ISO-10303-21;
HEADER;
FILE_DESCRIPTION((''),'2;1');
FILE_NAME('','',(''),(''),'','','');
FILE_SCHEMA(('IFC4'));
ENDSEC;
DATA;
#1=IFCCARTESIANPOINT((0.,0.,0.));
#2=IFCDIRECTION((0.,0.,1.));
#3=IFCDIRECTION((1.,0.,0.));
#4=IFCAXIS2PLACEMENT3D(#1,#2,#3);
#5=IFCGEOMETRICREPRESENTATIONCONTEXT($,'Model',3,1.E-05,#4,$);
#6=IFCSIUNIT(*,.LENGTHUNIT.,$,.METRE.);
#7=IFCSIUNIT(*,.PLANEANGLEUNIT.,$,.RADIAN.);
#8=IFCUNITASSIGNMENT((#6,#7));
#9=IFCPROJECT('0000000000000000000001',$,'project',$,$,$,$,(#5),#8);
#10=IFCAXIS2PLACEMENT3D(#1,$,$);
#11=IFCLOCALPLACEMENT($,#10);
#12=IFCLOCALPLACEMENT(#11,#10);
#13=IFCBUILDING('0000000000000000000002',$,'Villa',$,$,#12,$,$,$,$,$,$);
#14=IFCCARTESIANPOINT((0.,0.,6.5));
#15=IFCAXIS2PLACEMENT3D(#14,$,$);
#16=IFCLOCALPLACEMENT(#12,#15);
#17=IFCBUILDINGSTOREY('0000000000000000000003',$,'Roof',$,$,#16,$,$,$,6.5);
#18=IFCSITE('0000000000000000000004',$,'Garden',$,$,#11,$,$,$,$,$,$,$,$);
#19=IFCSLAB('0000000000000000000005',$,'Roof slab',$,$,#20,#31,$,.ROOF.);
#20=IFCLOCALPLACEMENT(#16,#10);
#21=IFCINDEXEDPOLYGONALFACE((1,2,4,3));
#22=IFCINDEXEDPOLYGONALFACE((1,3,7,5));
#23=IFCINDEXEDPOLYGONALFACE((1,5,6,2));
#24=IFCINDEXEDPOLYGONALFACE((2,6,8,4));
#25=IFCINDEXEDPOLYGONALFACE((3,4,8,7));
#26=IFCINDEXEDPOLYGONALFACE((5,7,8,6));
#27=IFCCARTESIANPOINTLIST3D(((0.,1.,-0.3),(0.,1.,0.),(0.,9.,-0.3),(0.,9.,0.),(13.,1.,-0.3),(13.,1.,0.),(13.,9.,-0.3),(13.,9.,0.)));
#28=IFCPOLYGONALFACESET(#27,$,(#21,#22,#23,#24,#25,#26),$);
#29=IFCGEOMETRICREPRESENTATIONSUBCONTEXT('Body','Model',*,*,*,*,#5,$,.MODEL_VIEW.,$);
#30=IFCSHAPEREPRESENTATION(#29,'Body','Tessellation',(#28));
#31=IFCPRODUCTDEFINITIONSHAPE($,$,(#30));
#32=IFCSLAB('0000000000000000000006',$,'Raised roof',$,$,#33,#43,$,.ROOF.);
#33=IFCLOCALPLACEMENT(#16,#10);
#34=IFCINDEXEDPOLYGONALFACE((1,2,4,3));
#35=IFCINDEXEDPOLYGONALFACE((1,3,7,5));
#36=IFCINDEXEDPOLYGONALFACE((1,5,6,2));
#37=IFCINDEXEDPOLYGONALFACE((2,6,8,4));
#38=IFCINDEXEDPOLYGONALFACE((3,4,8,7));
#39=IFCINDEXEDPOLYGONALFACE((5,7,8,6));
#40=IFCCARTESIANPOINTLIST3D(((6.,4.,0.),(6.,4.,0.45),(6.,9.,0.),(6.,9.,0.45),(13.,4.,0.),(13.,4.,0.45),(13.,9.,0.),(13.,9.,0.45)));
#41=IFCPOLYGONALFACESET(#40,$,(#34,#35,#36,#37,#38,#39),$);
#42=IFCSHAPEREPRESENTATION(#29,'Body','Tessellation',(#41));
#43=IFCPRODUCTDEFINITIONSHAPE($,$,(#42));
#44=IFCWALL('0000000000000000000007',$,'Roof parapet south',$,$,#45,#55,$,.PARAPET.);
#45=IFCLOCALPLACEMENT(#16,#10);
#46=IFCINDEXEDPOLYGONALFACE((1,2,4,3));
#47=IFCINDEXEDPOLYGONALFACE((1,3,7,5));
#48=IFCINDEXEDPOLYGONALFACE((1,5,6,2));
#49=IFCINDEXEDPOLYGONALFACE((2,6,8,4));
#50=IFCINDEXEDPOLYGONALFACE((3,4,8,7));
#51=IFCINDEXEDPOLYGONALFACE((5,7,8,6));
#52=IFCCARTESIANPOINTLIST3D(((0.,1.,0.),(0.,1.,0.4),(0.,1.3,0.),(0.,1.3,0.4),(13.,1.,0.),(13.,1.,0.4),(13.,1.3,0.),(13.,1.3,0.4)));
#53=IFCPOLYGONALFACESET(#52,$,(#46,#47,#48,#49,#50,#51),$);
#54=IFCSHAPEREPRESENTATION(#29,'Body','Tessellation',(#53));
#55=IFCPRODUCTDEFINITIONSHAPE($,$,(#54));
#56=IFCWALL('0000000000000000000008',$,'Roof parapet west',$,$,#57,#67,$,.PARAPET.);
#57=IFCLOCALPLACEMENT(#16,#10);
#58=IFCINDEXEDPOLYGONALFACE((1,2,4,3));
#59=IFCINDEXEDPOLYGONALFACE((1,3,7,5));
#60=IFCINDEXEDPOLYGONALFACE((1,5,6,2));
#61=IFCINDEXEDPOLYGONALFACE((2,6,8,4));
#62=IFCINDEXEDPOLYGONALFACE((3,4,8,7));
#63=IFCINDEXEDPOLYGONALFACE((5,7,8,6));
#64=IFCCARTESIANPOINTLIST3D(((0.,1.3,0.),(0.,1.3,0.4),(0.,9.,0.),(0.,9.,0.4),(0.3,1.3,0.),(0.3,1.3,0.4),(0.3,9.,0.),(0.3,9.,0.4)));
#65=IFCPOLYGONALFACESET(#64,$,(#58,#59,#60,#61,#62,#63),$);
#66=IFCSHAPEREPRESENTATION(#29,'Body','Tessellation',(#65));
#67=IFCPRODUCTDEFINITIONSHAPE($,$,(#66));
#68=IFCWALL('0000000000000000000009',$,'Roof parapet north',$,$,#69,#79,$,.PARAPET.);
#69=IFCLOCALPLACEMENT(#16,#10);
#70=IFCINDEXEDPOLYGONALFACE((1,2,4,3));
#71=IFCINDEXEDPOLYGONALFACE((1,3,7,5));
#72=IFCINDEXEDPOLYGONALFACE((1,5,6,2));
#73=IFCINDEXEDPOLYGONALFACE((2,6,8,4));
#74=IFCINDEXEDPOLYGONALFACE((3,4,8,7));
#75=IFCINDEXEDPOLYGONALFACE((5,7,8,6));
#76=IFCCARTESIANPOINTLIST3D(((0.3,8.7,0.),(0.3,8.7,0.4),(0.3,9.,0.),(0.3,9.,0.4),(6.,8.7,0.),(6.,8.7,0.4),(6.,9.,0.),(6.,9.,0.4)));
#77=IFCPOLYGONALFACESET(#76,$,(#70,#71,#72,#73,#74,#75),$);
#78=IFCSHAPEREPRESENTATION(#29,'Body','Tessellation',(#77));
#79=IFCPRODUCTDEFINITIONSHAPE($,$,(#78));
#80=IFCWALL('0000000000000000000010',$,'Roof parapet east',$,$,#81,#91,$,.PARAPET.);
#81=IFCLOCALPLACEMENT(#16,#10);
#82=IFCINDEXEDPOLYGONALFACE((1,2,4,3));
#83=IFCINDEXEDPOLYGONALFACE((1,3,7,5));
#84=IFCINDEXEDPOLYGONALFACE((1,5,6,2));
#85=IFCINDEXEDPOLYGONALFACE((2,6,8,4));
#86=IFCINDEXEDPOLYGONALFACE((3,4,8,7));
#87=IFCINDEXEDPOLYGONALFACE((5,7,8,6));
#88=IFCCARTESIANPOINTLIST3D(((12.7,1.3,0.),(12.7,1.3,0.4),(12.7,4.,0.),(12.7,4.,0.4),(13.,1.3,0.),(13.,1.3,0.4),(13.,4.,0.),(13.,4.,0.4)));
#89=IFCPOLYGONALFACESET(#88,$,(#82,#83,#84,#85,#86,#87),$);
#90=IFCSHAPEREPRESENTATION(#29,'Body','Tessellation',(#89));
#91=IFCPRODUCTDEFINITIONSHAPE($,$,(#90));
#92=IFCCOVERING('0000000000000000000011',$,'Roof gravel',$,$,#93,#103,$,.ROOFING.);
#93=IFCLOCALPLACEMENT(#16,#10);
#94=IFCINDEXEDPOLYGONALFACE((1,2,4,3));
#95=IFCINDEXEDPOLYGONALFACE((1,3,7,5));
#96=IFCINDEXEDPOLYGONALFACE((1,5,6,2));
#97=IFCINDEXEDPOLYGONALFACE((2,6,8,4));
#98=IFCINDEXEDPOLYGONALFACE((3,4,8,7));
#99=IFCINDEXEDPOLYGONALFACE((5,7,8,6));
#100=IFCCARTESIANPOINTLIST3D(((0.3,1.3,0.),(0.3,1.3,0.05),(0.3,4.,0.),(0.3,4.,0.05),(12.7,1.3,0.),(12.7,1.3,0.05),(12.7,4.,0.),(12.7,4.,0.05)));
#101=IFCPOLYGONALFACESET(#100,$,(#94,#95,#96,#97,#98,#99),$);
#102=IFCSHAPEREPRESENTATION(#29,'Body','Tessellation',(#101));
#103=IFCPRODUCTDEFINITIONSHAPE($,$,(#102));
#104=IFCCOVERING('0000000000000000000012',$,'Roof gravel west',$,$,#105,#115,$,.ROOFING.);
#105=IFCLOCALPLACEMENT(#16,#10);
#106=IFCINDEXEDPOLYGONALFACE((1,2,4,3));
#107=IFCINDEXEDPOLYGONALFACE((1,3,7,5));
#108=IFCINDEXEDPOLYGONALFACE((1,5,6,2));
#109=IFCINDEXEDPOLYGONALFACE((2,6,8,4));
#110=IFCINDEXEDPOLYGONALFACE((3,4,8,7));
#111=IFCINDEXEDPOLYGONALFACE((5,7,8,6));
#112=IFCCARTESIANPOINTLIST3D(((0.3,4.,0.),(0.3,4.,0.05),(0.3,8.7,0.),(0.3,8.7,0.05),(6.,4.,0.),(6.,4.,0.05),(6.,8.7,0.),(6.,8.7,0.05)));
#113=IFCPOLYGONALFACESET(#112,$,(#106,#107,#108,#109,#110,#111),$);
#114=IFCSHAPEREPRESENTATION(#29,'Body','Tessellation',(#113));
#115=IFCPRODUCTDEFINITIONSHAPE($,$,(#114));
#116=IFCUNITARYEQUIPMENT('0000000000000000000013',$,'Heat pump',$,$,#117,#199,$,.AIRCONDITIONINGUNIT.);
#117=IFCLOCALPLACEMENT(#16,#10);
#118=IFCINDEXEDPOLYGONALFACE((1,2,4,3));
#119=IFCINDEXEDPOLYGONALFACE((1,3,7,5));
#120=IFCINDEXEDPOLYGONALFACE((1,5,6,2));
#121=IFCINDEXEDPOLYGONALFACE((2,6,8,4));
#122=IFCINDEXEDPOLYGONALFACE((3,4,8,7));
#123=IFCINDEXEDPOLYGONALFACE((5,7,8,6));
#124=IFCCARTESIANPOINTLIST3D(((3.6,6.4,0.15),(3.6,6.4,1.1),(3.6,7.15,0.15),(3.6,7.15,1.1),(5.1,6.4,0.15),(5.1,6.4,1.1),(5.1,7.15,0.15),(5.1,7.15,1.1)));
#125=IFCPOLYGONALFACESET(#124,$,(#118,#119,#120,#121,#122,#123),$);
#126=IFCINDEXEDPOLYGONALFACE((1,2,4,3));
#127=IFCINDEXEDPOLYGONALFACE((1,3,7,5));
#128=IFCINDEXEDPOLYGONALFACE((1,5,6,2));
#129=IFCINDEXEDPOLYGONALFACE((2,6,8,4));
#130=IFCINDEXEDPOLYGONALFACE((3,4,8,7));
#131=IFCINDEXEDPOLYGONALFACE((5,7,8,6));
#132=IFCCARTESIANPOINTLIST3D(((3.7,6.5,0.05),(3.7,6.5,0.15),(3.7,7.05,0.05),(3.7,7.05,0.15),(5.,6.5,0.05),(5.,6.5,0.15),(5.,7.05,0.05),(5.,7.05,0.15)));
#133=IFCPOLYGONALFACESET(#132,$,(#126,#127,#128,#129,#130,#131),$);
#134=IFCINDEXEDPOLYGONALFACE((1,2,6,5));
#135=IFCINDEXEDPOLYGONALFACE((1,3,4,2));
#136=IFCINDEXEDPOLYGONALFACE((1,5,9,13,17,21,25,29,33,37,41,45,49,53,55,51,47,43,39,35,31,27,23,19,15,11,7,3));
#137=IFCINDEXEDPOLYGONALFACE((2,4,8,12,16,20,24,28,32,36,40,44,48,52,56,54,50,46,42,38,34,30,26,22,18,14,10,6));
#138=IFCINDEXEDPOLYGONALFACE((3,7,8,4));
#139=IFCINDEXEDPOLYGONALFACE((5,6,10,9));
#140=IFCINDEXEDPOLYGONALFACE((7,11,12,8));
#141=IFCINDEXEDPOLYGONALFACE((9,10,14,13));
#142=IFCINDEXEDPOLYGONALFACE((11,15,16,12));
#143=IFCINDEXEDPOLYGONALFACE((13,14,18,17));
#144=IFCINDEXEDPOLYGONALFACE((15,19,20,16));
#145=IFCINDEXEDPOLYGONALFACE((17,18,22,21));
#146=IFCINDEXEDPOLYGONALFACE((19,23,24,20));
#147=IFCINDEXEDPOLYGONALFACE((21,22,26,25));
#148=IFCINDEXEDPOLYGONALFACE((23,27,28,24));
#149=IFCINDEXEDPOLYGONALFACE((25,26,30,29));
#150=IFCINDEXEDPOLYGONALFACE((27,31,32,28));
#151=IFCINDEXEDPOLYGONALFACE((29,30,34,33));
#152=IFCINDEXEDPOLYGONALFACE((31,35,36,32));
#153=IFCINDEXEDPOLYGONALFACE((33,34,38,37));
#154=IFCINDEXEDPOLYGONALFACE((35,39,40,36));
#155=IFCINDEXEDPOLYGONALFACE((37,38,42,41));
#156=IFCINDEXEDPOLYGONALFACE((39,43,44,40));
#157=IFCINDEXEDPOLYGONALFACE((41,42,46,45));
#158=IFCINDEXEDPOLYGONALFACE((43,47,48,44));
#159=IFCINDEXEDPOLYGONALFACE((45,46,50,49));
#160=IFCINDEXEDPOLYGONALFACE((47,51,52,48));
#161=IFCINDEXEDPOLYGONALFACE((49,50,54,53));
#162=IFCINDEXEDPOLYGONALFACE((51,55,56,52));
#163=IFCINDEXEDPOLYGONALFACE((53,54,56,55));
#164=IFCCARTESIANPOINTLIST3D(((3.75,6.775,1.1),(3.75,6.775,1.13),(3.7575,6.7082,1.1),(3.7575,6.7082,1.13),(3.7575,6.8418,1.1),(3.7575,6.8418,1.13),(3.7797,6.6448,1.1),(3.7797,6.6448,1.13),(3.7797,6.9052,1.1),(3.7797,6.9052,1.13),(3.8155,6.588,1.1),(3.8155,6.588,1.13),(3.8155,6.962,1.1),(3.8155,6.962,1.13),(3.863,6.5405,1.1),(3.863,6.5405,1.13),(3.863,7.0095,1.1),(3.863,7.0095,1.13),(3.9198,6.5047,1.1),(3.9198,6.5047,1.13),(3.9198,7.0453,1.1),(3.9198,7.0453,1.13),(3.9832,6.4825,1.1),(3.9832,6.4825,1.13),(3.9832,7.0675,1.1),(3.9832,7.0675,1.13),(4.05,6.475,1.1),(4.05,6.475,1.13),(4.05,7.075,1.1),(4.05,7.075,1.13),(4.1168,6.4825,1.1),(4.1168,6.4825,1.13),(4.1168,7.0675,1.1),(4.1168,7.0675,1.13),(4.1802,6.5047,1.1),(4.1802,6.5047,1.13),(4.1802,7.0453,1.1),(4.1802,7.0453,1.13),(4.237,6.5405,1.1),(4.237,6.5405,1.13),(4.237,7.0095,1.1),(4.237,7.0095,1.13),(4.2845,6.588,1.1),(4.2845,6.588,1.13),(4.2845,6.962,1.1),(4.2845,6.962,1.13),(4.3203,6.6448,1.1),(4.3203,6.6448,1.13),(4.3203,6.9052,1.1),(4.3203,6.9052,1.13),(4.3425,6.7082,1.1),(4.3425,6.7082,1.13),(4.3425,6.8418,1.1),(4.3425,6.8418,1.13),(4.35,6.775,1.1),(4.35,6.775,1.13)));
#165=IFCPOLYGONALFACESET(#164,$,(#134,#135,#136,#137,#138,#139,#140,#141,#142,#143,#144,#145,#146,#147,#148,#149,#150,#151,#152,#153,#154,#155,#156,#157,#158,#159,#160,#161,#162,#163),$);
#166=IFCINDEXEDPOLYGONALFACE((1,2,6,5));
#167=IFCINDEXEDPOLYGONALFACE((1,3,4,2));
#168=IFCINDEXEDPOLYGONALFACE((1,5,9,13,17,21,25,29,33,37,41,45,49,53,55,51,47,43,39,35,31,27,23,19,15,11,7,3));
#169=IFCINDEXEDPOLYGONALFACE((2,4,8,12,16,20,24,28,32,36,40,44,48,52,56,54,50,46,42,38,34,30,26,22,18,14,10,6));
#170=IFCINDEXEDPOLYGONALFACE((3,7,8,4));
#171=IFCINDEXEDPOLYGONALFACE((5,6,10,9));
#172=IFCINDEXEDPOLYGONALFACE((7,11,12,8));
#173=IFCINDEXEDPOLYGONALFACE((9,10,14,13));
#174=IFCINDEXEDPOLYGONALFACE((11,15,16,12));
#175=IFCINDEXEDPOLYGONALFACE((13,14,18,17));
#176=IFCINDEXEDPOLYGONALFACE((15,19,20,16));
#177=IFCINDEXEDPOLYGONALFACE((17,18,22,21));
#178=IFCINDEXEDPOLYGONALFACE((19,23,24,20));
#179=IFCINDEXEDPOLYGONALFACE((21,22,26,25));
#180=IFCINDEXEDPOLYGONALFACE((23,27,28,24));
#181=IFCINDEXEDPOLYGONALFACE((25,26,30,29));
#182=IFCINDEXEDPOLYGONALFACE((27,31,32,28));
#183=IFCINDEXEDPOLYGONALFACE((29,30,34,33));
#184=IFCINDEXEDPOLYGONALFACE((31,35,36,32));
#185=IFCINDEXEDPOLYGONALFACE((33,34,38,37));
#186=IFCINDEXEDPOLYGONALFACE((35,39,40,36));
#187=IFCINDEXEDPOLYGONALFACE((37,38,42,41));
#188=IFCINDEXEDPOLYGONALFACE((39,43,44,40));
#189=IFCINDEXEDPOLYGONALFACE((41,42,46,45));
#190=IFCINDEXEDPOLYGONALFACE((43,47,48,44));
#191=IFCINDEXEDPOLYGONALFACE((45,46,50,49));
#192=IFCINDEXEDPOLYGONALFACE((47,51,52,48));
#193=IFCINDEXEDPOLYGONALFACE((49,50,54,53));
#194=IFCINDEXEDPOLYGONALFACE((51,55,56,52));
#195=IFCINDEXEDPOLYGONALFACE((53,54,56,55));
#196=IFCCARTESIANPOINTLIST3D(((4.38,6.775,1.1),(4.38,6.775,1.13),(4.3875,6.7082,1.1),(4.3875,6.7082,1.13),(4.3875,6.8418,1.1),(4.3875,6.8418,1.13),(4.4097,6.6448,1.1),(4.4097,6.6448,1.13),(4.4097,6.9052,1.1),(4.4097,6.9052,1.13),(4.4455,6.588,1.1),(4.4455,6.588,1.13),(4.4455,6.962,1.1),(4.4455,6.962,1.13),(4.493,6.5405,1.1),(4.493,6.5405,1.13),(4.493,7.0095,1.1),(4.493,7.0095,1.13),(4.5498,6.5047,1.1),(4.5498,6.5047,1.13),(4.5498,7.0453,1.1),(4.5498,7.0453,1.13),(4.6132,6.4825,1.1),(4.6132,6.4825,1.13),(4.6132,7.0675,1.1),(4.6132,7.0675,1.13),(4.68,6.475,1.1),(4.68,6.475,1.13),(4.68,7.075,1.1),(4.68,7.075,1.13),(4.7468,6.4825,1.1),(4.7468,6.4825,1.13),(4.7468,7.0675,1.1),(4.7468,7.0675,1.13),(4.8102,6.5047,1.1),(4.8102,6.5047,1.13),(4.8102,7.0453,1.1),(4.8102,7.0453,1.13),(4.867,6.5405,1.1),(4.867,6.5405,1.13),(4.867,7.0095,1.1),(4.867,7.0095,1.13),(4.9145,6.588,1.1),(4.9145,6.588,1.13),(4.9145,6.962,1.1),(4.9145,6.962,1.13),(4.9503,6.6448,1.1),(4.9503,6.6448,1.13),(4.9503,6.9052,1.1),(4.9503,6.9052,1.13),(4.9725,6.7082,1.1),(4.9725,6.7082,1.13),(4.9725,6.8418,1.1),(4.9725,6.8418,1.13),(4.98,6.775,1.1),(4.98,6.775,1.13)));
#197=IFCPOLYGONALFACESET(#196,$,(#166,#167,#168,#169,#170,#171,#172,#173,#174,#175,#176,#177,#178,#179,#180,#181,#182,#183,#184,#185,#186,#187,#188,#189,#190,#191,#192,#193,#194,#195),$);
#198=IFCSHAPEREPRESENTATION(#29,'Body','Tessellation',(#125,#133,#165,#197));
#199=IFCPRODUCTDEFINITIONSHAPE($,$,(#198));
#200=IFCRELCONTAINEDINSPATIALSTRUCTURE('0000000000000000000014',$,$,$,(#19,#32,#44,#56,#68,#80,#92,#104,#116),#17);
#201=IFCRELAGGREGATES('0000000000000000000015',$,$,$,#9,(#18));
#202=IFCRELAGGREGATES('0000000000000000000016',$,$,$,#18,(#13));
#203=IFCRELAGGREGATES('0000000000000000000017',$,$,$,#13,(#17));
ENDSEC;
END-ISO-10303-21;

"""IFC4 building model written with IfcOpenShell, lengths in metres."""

from ifc_helpers import new_model, si_unit, frame, frame_2d, origin, origin_with_axes, place, context, subcontext, project, spatial, polyline, rectangle, circle, outline, extrude, element, save


model = new_model("IFC4")

# Units and contexts
model_context = context("Model", 3, precision=1e-05, world=origin_with_axes())
body_context = subcontext(model_context, "Body", "Model", "MODEL_VIEW")
ifc_project = project(units=[si_unit("LENGTHUNIT", "METRE"), si_unit("PLANEANGLEUNIT", "RADIAN")], contexts=[model_context])

# Site, building, storey
site_placement = place(None, origin())
site = spatial("IfcSite", under=ifc_project, at=site_placement, Name="Garden")
building_placement = place(site_placement, origin())
building = spatial("IfcBuilding", under=site, at=building_placement, Name="Villa")
storey_placement = place(building_placement, frame((0.0, 0.0, 6.5)))
storey = spatial("IfcBuildingStorey", under=building, at=storey_placement, Name="Roof", Elevation=6.5)

# Slabs
slab_1_placement = place(storey_placement, frame((0.0, 0.0, -0.3)))
element("IfcSlab", 1, at=slab_1_placement, inside=storey, Name="Roof slab", PredefinedType="ROOF", context=body_context, shape_type="SweptSolid", body=[
    extrude(outline(polyline([(0.0, 1.0), (13.0, 1.0), (13.0, 9.0), (0.0, 9.0), (0.0, 1.0)])), origin(), (0.0, 0.0, 1.0), 0.3),
])
slab_2_placement = place(storey_placement, origin())
element("IfcSlab", 2, at=slab_2_placement, inside=storey, Name="Raised roof", PredefinedType="ROOF", context=body_context, shape_type="SweptSolid", body=[
    extrude(outline(polyline([(6.0, 4.0), (13.0, 4.0), (13.0, 9.0), (6.0, 9.0), (6.0, 4.0)])), origin(), (0.0, 0.0, 1.0), 0.45),
])

# Walls
wall_1_placement = place(storey_placement, origin())
element("IfcWall", 3, at=wall_1_placement, inside=storey, Name="Roof parapet south", PredefinedType="PARAPET", context=body_context, shape_type="SweptSolid", body=[
    extrude(rectangle(XDim=13.0, YDim=0.3, at=frame_2d((6.5, 0.15))), frame((0.0, 1.0, 0.0)), (0.0, 0.0, 1.0), 0.4),
])
wall_2_placement = place(storey_placement, origin())
element("IfcWall", 4, at=wall_2_placement, inside=storey, Name="Roof parapet west", PredefinedType="PARAPET", context=body_context, shape_type="SweptSolid", body=[
    extrude(rectangle(XDim=0.3, YDim=7.7, at=frame_2d((0.15, 3.85))), frame((0.0, 1.3, 0.0)), (0.0, 0.0, 1.0), 0.4),
])
wall_3_placement = place(storey_placement, origin())
element("IfcWall", 5, at=wall_3_placement, inside=storey, Name="Roof parapet north", PredefinedType="PARAPET", context=body_context, shape_type="SweptSolid", body=[
    extrude(rectangle(XDim=5.7, YDim=0.3, at=frame_2d((2.85, 0.15))), frame((0.3, 8.7, 0.0)), (0.0, 0.0, 1.0), 0.4),
])
wall_4_placement = place(storey_placement, origin())
element("IfcWall", 6, at=wall_4_placement, inside=storey, Name="Roof parapet east", PredefinedType="PARAPET", context=body_context, shape_type="SweptSolid", body=[
    extrude(rectangle(XDim=0.3, YDim=2.7, at=frame_2d((0.15, 1.35))), frame((12.7, 1.3, 0.0)), (0.0, 0.0, 1.0), 0.4),
])

# Coverings
covering_1_placement = place(storey_placement, origin())
element("IfcCovering", 7, at=covering_1_placement, inside=storey, Name="Roof gravel", PredefinedType="ROOFING", context=body_context, shape_type="SweptSolid", body=[
    extrude(rectangle(XDim=12.4, YDim=2.7, at=frame_2d((6.2, 1.35))), frame((0.3, 1.3, 0.0)), (0.0, 0.0, 1.0), 0.05),
])
covering_2_placement = place(storey_placement, origin())
element("IfcCovering", 8, at=covering_2_placement, inside=storey, Name="Roof gravel west", PredefinedType="ROOFING", context=body_context, shape_type="SweptSolid", body=[
    extrude(rectangle(XDim=5.7, YDim=4.7, at=frame_2d((2.85, 2.35))), frame((0.3, 4.0, 0.0)), (0.0, 0.0, 1.0), 0.05),
])

# Unitary equipment
unitary_equipment_placement = place(storey_placement, frame((3.6, 6.4, 0.05)))
element("IfcUnitaryEquipment", 9, at=unitary_equipment_placement, inside=storey, Name="Heat pump", PredefinedType="AIRCONDITIONINGUNIT", context=body_context, shape_type="SweptSolid", body=[
    extrude(rectangle(XDim=1.5, YDim=0.75, at=frame_2d((0.75, 0.375))), frame((0.0, 0.0, 0.1)), (0.0, 0.0, 1.0), 0.95),
    extrude(rectangle(XDim=1.3, YDim=0.55, at=frame_2d((0.65, 0.275))), frame((0.1, 0.1, 0.0)), (0.0, 0.0, 1.0), 0.1),
    extrude(circle(Radius=0.3, at=frame_2d((0.45, 0.375))), frame((0.0, 0.0, 1.05)), (0.0, 0.0, 1.0), 0.03),
    extrude(circle(Radius=0.3, at=frame_2d((1.08, 0.375))), frame((0.0, 0.0, 1.05)), (0.0, 0.0, 1.0), 0.03),
])

save(model, "model.ifc")
